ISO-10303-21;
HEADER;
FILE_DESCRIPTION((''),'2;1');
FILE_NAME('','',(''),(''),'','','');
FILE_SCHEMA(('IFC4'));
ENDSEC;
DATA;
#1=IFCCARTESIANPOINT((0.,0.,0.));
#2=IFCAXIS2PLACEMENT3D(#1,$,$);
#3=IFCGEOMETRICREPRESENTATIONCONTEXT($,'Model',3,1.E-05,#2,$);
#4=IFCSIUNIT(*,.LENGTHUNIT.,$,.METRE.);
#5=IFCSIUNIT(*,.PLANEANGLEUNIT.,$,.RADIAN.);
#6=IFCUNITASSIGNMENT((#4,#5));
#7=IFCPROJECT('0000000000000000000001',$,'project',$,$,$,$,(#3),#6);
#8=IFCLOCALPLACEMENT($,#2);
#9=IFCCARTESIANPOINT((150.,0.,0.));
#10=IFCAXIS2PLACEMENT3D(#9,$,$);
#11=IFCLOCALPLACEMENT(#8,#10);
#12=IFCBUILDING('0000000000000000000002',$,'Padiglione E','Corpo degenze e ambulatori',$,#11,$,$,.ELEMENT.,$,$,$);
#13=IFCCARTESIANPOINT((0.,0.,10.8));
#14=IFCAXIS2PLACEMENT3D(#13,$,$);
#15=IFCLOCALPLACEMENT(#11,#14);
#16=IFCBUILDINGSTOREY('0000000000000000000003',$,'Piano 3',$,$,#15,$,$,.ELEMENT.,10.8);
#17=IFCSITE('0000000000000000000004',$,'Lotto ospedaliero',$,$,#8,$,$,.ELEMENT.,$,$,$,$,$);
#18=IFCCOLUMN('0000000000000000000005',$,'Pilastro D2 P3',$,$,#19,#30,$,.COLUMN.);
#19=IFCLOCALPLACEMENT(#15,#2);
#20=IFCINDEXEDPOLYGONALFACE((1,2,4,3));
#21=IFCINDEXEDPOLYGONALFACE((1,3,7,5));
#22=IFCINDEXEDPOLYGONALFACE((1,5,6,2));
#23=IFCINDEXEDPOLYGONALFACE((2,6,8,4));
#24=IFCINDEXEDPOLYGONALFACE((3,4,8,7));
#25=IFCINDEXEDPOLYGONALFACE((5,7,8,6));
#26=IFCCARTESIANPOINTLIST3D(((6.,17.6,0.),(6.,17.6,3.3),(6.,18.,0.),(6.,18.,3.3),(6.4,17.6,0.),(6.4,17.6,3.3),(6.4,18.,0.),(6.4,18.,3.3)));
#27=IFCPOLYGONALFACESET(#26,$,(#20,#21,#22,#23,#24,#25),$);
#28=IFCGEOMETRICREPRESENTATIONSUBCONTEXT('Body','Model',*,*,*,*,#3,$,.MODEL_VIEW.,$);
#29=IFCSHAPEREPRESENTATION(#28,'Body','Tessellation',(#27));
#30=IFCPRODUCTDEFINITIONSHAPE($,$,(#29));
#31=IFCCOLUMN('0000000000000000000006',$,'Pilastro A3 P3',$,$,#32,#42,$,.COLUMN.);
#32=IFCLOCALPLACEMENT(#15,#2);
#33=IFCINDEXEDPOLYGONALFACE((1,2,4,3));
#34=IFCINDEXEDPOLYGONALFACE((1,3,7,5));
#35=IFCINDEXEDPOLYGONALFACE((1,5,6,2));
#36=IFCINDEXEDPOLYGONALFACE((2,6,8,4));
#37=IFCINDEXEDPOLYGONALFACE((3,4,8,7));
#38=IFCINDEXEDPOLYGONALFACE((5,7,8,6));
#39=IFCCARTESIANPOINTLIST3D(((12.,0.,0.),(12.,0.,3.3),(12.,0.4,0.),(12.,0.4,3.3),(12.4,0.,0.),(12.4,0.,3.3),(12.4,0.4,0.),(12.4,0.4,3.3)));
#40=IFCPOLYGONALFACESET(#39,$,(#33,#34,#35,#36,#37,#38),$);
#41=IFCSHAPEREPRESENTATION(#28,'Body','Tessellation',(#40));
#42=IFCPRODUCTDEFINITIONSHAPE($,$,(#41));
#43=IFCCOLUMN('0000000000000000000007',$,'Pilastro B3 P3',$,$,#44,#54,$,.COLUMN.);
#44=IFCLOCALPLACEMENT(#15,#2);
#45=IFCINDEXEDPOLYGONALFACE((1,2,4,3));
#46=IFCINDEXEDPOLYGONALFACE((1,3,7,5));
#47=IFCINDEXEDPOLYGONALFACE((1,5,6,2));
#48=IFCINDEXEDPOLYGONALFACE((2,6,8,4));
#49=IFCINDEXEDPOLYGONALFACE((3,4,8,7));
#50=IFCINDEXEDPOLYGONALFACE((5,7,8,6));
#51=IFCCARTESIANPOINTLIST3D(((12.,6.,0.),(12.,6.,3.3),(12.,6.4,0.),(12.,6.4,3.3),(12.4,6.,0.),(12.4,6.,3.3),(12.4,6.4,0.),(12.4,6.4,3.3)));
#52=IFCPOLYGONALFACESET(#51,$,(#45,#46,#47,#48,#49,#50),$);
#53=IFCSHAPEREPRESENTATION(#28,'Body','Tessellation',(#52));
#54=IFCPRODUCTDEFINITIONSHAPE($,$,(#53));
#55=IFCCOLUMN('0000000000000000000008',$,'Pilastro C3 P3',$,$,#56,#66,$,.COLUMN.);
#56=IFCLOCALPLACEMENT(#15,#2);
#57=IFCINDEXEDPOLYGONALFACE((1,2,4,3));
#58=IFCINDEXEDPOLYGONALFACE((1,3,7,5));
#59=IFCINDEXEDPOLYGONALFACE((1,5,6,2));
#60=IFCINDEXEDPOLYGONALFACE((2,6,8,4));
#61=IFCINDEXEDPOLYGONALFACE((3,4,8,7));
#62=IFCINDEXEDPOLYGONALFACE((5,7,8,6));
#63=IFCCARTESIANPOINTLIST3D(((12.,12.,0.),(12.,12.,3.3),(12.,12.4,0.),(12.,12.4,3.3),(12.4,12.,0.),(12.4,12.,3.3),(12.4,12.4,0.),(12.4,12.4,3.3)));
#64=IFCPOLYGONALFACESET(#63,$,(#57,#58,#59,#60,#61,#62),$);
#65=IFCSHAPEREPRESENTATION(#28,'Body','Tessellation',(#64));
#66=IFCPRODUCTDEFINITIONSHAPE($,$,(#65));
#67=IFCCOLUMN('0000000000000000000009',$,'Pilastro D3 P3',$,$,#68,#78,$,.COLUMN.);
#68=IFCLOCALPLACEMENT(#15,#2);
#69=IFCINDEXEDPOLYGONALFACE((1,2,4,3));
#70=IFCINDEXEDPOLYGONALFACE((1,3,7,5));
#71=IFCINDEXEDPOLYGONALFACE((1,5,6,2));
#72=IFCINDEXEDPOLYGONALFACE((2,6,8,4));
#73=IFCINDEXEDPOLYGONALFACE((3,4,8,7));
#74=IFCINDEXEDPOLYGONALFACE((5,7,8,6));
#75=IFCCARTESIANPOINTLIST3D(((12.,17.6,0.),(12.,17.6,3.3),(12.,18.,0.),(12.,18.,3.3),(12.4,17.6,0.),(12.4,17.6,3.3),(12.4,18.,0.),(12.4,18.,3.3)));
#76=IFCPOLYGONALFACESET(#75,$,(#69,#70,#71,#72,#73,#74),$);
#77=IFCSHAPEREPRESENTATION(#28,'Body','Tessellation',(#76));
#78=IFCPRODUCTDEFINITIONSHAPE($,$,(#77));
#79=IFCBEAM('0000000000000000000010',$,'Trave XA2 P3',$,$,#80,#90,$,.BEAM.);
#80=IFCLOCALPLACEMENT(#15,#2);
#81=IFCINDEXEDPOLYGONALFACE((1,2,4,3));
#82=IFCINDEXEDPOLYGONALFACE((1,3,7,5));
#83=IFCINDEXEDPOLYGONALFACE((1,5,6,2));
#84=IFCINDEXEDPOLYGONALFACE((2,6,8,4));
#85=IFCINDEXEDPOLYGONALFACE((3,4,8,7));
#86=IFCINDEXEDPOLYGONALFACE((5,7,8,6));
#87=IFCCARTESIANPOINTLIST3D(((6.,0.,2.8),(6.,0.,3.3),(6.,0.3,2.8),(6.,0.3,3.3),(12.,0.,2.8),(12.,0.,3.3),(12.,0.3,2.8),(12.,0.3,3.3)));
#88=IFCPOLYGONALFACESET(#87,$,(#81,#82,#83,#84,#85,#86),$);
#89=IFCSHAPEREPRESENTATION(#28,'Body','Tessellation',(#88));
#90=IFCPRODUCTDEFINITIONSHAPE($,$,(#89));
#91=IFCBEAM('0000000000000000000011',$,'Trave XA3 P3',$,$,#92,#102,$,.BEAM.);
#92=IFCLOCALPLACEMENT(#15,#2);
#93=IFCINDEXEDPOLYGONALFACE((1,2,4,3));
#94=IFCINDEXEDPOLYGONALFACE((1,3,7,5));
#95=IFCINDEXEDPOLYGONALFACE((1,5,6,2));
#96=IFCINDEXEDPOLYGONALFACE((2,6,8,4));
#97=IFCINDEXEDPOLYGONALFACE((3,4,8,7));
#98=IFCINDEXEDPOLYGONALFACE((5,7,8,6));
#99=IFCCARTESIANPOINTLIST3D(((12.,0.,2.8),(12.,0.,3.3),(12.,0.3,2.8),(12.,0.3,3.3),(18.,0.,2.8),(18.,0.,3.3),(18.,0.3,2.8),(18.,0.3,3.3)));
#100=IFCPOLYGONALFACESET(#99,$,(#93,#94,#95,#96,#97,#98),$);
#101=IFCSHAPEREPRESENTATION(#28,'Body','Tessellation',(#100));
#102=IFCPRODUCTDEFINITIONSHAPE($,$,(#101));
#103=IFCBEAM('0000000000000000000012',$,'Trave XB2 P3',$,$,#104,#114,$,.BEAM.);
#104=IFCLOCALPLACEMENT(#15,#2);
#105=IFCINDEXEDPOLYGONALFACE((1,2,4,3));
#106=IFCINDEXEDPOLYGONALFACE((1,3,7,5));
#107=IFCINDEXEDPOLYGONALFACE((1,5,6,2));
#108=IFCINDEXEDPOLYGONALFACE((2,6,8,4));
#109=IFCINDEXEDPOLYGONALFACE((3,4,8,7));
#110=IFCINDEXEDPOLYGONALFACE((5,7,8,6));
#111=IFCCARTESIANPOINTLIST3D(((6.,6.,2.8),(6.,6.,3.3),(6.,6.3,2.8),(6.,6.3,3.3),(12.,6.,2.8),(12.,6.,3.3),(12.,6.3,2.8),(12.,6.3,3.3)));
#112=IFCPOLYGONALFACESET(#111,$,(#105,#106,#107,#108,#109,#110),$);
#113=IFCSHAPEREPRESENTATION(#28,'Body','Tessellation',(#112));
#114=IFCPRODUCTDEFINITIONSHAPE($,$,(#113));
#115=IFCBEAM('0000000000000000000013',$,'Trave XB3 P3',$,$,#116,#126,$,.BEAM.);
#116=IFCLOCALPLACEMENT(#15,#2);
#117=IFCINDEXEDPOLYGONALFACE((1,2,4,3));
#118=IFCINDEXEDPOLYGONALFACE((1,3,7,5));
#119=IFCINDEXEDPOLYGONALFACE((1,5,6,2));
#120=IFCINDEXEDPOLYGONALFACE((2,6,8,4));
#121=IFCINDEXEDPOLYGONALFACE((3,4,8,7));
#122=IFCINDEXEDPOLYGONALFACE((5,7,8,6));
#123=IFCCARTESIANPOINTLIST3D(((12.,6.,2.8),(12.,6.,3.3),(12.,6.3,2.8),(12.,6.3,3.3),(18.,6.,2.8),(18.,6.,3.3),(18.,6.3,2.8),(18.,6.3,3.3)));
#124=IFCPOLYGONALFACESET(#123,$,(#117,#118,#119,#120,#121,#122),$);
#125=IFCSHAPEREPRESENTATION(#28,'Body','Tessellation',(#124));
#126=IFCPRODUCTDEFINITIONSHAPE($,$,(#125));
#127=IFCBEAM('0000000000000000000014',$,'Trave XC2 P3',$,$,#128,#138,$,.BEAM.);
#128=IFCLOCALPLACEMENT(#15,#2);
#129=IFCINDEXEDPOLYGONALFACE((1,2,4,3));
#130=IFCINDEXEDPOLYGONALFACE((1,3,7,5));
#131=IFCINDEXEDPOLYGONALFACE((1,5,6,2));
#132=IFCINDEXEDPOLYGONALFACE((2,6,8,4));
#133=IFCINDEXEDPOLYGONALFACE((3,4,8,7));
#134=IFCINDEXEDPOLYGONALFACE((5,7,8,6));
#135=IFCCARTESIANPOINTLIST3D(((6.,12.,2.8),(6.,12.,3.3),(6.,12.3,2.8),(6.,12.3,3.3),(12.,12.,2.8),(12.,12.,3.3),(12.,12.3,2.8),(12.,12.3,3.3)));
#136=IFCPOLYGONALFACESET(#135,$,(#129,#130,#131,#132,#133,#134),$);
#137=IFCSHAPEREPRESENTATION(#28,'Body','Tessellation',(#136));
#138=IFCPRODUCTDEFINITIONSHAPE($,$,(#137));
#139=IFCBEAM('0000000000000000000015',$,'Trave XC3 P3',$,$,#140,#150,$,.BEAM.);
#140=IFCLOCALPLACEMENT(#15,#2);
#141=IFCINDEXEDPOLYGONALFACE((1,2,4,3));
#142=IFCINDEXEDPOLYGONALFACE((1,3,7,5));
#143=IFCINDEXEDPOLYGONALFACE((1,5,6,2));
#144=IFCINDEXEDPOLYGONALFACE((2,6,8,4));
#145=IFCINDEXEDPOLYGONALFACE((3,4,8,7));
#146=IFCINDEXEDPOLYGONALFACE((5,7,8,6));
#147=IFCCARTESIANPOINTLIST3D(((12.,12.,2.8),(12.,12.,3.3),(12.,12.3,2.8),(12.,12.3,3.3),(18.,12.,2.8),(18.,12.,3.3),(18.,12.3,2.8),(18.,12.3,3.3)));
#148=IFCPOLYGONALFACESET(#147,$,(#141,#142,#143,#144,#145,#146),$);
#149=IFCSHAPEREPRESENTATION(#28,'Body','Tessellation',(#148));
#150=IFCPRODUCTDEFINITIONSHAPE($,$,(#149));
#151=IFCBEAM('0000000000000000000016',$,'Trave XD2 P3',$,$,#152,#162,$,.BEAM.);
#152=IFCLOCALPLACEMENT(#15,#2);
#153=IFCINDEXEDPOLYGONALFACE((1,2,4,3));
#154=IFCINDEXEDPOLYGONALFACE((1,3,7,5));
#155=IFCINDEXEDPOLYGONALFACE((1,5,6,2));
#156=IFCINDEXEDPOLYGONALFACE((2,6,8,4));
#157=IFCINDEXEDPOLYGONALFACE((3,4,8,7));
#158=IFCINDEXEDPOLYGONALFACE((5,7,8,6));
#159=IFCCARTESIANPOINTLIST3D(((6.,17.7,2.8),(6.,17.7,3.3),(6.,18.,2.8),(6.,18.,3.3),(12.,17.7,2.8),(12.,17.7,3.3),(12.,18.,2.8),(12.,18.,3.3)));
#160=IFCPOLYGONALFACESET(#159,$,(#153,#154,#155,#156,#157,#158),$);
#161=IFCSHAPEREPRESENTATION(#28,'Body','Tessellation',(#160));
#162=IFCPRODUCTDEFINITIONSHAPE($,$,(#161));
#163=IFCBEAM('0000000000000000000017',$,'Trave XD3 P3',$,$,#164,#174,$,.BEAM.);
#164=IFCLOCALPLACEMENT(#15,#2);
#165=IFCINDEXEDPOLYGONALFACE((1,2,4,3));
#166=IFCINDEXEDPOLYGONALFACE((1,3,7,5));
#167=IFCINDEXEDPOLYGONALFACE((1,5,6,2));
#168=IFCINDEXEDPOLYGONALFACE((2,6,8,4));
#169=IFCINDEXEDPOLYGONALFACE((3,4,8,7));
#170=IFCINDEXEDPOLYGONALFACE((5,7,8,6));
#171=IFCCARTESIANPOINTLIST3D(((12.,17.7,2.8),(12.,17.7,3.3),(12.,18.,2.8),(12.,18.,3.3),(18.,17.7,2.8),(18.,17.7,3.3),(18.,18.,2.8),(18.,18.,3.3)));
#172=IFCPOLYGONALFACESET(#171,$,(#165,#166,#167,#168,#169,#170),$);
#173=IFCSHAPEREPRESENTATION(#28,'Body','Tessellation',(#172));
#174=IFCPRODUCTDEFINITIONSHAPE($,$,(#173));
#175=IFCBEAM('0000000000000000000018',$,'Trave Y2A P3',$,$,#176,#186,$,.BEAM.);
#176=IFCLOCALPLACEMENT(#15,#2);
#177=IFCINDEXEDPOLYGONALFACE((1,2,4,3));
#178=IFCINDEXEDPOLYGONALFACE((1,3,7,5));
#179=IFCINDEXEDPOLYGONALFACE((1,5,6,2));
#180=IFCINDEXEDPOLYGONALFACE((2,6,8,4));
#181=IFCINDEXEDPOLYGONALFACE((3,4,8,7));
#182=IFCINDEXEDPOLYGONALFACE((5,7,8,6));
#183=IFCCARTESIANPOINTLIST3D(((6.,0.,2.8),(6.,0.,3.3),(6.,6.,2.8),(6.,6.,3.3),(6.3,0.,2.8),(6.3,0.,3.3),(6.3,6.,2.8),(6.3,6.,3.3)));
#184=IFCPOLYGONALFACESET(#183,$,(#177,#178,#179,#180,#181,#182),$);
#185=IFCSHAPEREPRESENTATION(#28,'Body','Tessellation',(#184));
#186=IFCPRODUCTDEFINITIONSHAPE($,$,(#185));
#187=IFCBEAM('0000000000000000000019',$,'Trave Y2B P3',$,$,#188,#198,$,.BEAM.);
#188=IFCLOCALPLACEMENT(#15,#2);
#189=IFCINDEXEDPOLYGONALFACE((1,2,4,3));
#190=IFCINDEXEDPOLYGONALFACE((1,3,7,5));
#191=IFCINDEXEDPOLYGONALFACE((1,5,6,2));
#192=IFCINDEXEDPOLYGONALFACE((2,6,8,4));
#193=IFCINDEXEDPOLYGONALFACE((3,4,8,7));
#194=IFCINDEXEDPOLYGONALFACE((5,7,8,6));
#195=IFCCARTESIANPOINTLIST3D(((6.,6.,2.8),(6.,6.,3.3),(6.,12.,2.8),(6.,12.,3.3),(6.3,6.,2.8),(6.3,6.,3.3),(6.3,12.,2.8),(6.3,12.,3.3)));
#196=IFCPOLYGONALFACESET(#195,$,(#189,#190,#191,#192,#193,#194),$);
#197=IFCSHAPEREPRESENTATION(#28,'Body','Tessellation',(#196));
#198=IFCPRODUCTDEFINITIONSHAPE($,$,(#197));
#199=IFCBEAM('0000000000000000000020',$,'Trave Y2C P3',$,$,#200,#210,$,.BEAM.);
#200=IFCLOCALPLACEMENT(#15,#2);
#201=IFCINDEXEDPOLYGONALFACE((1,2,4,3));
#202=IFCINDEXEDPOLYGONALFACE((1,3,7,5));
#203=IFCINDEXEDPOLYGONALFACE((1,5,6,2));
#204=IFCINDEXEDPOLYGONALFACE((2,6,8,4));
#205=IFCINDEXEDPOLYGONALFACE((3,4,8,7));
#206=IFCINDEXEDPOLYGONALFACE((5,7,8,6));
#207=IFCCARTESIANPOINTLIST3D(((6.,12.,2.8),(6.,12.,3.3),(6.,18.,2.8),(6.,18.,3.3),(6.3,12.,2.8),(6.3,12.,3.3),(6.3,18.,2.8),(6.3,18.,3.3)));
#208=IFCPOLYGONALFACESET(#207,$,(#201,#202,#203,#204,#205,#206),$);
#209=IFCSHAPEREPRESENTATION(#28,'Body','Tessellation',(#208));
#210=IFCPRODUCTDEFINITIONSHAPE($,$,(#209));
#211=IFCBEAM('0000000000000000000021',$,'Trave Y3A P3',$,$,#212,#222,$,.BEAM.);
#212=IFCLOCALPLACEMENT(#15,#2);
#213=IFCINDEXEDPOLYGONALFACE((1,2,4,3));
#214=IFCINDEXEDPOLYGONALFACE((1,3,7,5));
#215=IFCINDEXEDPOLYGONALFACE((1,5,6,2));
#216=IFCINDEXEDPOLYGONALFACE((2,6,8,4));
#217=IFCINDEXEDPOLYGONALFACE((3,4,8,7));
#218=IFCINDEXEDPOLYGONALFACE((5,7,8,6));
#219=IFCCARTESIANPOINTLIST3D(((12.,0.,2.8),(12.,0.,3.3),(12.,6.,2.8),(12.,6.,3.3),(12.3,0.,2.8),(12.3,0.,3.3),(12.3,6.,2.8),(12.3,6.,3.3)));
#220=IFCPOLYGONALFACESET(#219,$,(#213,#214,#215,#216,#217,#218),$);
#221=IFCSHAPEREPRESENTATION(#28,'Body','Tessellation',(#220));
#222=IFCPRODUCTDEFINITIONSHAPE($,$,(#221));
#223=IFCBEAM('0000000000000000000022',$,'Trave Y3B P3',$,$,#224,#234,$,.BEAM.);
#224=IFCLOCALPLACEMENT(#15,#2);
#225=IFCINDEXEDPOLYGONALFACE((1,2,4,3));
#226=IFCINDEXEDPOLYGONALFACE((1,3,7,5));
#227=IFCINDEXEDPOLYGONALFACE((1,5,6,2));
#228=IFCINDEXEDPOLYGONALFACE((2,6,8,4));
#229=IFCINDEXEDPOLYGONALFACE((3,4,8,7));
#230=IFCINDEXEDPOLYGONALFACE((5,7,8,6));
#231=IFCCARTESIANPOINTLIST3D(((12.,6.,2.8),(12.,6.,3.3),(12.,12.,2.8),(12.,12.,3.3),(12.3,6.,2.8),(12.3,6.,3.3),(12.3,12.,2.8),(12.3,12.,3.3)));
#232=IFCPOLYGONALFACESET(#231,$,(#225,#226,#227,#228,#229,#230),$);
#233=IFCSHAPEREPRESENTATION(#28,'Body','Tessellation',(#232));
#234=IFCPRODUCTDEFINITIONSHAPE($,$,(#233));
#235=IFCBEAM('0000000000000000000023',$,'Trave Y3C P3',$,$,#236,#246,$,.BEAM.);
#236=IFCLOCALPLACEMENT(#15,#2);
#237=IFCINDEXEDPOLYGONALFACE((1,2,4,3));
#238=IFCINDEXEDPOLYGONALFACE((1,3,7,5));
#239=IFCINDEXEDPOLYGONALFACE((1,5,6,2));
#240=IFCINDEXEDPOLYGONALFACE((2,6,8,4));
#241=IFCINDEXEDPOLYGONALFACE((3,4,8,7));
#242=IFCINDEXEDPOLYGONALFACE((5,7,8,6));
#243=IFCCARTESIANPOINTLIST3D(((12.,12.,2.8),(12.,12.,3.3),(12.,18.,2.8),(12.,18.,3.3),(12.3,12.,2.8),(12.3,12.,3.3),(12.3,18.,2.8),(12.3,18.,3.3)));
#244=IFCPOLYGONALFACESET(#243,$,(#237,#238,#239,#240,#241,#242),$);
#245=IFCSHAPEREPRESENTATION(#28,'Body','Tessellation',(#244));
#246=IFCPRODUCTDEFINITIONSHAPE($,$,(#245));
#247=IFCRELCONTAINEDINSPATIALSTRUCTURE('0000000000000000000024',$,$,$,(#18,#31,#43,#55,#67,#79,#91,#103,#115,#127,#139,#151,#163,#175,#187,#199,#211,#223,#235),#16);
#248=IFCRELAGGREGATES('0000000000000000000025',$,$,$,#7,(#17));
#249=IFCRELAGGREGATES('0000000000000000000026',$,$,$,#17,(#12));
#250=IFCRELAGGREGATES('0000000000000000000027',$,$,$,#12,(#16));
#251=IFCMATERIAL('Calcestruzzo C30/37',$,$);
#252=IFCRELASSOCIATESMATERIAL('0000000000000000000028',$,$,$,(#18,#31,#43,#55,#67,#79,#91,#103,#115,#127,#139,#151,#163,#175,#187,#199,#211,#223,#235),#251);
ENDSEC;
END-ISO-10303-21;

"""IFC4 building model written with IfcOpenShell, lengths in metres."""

from ifc_helpers import new_model, si_unit, frame, frame_2d, origin, place, context, subcontext, project, spatial, rectangle, extrude, material, element, save


model = new_model("IFC4")

# Units and contexts
model_context = context("Model", 3, precision=1e-05, world=origin())
body_context = subcontext(model_context, "Body", "Model", "MODEL_VIEW")
ifc_project = project(units=[si_unit("LENGTHUNIT", "METRE"), si_unit("PLANEANGLEUNIT", "RADIAN")], contexts=[model_context])

# Site, building, storey
site_placement = place(None, origin())
site = spatial("IfcSite", under=ifc_project, at=site_placement, Name="Lotto ospedaliero", CompositionType="ELEMENT")
building_placement = place(site_placement, frame((150.0, 0.0, 0.0)))
building = spatial("IfcBuilding", under=site, at=building_placement, Name="Padiglione E", Description="Corpo degenze e ambulatori", CompositionType="ELEMENT")
storey_placement = place(building_placement, frame((0.0, 0.0, 10.8)))
storey = spatial("IfcBuildingStorey", under=building, at=storey_placement, Name="Piano 3", CompositionType="ELEMENT", Elevation=10.8)

# Columns
ifc_material_1 = material(Name="Calcestruzzo C30/37")
for number, where, name in (
    (1, (6.0, 17.6, 0.0), "Pilastro D2 P3"),
    (2, (12.0, 0.0, 0.0), "Pilastro A3 P3"),
    (3, (12.0, 6.0, 0.0), "Pilastro B3 P3"),
    (4, (12.0, 12.0, 0.0), "Pilastro C3 P3"),
    (5, (12.0, 17.6, 0.0), "Pilastro D3 P3"),
):
    element("IfcColumn", number, at=place(storey_placement, frame(where)), inside=storey, material=ifc_material_1, Name=name, PredefinedType="COLUMN", context=body_context, shape_type="SweptSolid", body=[
        extrude(rectangle(XDim=0.4, YDim=0.4, at=frame_2d((0.2, 0.2))), origin(), (0.0, 0.0, 1.0), 3.3),
    ])

# Beams
for number, where, name in (
    (6, (6.0, 0.0, 2.8), "Trave XA2 P3"),
    (7, (12.0, 0.0, 2.8), "Trave XA3 P3"),
    (8, (6.0, 6.0, 2.8), "Trave XB2 P3"),
    (9, (12.0, 6.0, 2.8), "Trave XB3 P3"),
    (10, (6.0, 12.0, 2.8), "Trave XC2 P3"),
    (11, (12.0, 12.0, 2.8), "Trave XC3 P3"),
    (12, (6.0, 17.7, 2.8), "Trave XD2 P3"),
    (13, (12.0, 17.7, 2.8), "Trave XD3 P3"),
):
    element("IfcBeam", number, at=place(storey_placement, frame(where)), inside=storey, material=ifc_material_1, Name=name, PredefinedType="BEAM", context=body_context, shape_type="SweptSolid", body=[
        extrude(rectangle(XDim=6.0, YDim=0.3, at=frame_2d((3.0, 0.15))), origin(), (0.0, 0.0, 1.0), 0.5),
    ])
for number, where, name in (
    (14, (6.0, 0.0, 2.8), "Trave Y2A P3"),
    (15, (6.0, 6.0, 2.8), "Trave Y2B P3"),
    (16, (6.0, 12.0, 2.8), "Trave Y2C P3"),
    (17, (12.0, 0.0, 2.8), "Trave Y3A P3"),
    (18, (12.0, 6.0, 2.8), "Trave Y3B P3"),
    (19, (12.0, 12.0, 2.8), "Trave Y3C P3"),
):
    element("IfcBeam", number, at=place(storey_placement, frame(where)), inside=storey, material=ifc_material_1, Name=name, PredefinedType="BEAM", context=body_context, shape_type="SweptSolid", body=[
        extrude(rectangle(XDim=0.3, YDim=6.0, at=frame_2d((0.15, 3.0))), origin(), (0.0, 0.0, 1.0), 0.5),
    ])

save(model, "model.ifc")
